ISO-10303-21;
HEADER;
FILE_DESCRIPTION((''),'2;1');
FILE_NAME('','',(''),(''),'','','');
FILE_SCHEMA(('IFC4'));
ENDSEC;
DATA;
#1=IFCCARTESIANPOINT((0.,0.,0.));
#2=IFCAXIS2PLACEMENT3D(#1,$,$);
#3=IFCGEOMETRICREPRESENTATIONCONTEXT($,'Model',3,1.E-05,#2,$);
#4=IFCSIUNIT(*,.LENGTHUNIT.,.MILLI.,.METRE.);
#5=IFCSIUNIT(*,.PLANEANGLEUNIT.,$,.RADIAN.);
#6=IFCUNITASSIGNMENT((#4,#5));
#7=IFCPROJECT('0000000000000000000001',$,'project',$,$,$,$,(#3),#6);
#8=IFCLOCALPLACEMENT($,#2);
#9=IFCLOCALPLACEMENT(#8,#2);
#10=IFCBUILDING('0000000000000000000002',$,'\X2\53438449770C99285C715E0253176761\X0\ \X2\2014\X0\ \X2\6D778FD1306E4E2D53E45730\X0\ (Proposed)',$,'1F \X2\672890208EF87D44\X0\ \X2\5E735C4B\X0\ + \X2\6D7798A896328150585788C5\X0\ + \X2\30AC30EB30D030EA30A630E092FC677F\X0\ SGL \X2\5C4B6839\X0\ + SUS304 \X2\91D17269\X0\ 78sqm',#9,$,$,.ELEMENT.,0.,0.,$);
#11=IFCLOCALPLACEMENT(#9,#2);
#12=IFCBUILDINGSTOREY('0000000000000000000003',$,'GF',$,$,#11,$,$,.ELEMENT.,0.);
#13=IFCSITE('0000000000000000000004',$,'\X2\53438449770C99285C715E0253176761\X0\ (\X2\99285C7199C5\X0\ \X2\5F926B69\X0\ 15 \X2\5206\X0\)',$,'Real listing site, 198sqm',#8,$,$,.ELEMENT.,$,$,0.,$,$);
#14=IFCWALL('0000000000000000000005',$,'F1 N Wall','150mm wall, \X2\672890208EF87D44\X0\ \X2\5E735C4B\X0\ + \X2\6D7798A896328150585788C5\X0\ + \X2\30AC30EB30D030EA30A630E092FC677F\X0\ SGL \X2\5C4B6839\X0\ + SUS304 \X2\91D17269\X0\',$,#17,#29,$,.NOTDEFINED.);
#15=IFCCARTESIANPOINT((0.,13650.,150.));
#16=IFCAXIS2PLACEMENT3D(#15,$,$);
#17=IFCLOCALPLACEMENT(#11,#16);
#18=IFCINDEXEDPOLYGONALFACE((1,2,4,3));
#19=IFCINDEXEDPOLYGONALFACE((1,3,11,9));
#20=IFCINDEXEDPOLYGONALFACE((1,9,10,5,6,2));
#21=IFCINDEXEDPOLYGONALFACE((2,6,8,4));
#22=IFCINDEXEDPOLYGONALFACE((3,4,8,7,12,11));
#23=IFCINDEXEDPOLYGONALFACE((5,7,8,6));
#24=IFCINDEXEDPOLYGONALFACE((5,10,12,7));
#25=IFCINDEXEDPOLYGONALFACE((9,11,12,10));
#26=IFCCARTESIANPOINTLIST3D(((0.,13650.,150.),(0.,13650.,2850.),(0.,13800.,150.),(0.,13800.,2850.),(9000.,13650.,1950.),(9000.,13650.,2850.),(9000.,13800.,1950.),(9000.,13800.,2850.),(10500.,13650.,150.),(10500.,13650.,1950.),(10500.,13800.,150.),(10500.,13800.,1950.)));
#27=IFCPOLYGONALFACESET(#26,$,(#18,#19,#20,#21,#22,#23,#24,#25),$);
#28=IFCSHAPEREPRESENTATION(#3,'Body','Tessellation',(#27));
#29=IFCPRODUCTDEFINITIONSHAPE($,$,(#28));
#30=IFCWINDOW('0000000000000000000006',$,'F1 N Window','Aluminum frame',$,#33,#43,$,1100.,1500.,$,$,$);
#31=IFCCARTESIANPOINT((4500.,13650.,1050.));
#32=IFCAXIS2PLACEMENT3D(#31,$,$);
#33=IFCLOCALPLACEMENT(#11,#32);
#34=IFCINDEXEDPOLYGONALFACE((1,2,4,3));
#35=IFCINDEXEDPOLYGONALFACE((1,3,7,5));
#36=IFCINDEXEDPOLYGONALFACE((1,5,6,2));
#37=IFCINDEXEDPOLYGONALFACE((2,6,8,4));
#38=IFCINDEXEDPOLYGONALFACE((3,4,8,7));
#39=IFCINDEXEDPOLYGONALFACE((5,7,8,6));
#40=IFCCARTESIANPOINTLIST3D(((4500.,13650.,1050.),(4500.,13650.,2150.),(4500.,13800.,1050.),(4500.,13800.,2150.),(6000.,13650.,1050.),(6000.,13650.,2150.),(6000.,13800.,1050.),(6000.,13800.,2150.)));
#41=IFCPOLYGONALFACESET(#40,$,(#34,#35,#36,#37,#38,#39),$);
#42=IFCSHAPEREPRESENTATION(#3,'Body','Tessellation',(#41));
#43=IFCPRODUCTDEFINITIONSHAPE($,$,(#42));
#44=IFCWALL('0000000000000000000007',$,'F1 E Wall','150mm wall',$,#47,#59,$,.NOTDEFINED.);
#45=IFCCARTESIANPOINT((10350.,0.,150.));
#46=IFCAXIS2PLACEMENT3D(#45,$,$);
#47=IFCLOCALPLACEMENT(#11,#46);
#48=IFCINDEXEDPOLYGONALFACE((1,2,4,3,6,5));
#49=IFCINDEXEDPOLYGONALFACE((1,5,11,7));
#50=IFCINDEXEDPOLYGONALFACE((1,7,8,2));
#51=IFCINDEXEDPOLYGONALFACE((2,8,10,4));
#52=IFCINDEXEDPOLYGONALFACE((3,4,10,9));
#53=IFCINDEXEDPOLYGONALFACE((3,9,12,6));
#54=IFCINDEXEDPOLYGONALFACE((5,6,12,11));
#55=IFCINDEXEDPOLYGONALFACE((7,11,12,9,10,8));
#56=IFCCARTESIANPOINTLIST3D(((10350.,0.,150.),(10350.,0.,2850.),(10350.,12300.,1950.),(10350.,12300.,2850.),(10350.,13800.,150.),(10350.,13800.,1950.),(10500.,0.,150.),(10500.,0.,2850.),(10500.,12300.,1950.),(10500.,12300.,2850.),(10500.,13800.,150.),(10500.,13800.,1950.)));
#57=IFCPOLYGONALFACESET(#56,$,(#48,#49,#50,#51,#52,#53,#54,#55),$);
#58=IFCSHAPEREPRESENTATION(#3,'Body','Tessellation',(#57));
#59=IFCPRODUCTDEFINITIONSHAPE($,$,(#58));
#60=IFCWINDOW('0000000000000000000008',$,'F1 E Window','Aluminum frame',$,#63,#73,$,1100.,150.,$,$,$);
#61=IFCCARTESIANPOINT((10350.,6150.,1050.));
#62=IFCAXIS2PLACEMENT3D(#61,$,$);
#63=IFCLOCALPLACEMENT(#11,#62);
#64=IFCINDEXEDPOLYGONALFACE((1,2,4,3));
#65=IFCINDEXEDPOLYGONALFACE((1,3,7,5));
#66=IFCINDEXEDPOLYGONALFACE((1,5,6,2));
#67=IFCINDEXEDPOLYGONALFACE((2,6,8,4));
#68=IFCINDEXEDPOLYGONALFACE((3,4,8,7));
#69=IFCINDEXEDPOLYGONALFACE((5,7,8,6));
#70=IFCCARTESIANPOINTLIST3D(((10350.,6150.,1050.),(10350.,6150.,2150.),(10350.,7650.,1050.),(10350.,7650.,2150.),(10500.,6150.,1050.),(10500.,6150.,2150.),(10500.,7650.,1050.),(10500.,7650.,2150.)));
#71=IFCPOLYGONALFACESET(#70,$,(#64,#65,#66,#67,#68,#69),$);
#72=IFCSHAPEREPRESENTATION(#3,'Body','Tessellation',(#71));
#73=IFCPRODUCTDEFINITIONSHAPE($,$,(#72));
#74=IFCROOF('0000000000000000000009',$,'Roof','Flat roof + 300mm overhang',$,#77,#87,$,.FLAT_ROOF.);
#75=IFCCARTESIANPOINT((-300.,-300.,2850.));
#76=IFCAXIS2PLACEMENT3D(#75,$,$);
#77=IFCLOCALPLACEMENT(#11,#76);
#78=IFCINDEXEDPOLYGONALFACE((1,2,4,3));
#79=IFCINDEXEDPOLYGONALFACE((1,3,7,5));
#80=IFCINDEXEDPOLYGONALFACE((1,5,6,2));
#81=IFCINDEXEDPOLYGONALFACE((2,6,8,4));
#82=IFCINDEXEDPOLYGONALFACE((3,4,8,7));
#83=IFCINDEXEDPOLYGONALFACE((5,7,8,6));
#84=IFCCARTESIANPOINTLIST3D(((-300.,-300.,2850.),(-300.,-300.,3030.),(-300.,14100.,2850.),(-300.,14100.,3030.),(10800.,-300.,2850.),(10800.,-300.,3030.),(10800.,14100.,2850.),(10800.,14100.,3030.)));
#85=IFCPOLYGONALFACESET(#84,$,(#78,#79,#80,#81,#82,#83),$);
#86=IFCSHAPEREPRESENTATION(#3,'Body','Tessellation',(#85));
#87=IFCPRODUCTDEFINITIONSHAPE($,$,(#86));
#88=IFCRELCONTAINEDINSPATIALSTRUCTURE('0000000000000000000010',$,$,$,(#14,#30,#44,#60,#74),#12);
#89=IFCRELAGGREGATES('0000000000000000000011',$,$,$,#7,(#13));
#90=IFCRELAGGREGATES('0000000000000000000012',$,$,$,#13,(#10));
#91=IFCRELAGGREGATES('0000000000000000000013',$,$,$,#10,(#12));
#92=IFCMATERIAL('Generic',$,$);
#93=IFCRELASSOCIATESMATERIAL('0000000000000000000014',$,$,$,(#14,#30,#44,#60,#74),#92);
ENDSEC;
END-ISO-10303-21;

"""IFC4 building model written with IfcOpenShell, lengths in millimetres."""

from ifc_helpers import new_model, si_unit, frame, frame_2d, origin, place, context, project, spatial, rectangle, extrude, material, element, fill, save


model = new_model("IFC4")

# Units and contexts
model_context = context("Model", 3, precision=1e-05, world=origin())
ifc_project = project(units=[si_unit("LENGTHUNIT", "METRE", prefix="MILLI"), si_unit("PLANEANGLEUNIT", "RADIAN")], contexts=[model_context])

# Site, building, storey
site_placement = place(None, origin())
site = spatial("IfcSite", under=ifc_project, at=site_placement, Name="千葉県館山市北条 (館山駅 徒歩 15 分)", ObjectType="Real listing site, 198sqm", CompositionType="ELEMENT", RefElevation=0.0)
building_placement = place(site_placement, origin())
building = spatial("IfcBuilding", under=site, at=building_placement, Name="千葉県館山市北条 — 海近の中古地 (Proposed)", ObjectType="1F 木造軸組 平屋 + 海風防腐塗装 + ガルバリウム鋼板 SGL 屋根 + SUS304 金物 78sqm", CompositionType="ELEMENT", ElevationOfRefHeight=0.0, ElevationOfTerrain=0.0)
storey_placement = place(building_placement, origin())
storey = spatial("IfcBuildingStorey", under=building, at=storey_placement, Name="GF", CompositionType="ELEMENT", Elevation=0.0)

# Wall, opening, window
ifc_material_1 = material(Name="Generic")
wall_1_placement = place(storey_placement, frame((0.0, 13650.0, 150.0)))
wall_1 = element("IfcWall", 1, at=wall_1_placement, inside=storey, material=ifc_material_1, Name="F1 N Wall", Description="150mm wall, 木造軸組 平屋 + 海風防腐塗装 + ガルバリウム鋼板 SGL 屋根 + SUS304 金物", PredefinedType="NOTDEFINED", context=model_context, shape_type="SweptSolid", body=[
    extrude(rectangle(XDim=10500.0, YDim=150.0, at=frame_2d((5250.0, 75.0))), frame((0.0, 13650.0, 150.0)), (0.0, 0.0, 1.0), 2700.0),
])
opening_1_placement = place(storey_placement, frame((4500.0, 13650.0, 1050.0)))
opening_1 = element("IfcOpeningElement", 2, at=opening_1_placement, cuts=wall_1, PredefinedType="NOTDEFINED", context=model_context, shape_type="SweptSolid", body=[
    extrude(rectangle(XDim=1500.0, YDim=150.0, at=frame_2d((750.0, 75.0))), frame((4500.0, 13650.0, 1050.0)), (0.0, 0.0, 1.0), 1100.0),
])
window_1_placement = place(storey_placement, frame((4500.0, 13650.0, 1050.0)))
window_1 = element("IfcWindow", 3, at=window_1_placement, inside=storey, material=ifc_material_1, Name="F1 N Window", Description="Aluminum frame", OverallHeight=1100.0, OverallWidth=1500.0, context=model_context, shape_type="SweptSolid", body=[
    extrude(rectangle(XDim=1500.0, YDim=150.0, at=frame_2d((750.0, 75.0))), frame((4500.0, 13650.0, 1050.0)), (0.0, 0.0, 1.0), 1100.0),
])
fill(opening_1, window_1)

# Wall, opening, window
wall_2_placement = place(storey_placement, frame((10350.0, 0.0, 150.0)))
wall_2 = element("IfcWall", 4, at=wall_2_placement, inside=storey, material=ifc_material_1, Name="F1 E Wall", Description="150mm wall", PredefinedType="NOTDEFINED", context=model_context, shape_type="SweptSolid", body=[
    extrude(rectangle(XDim=150.0, YDim=13800.0, at=frame_2d((75.0, 6900.0))), frame((10350.0, 0.0, 150.0)), (0.0, 0.0, 1.0), 2700.0),
])
opening_2_placement = place(storey_placement, frame((10350.0, 6150.0, 1050.0)))
opening_2 = element("IfcOpeningElement", 5, at=opening_2_placement, cuts=wall_2, PredefinedType="NOTDEFINED", context=model_context, shape_type="SweptSolid", body=[
    extrude(rectangle(XDim=150.0, YDim=1500.0, at=frame_2d((75.0, 750.0))), frame((10350.0, 6150.0, 1050.0)), (0.0, 0.0, 1.0), 1100.0),
])
window_2_placement = place(storey_placement, frame((10350.0, 6150.0, 1050.0)))
window_2 = element("IfcWindow", 6, at=window_2_placement, inside=storey, material=ifc_material_1, Name="F1 E Window", Description="Aluminum frame", OverallHeight=1100.0, OverallWidth=150.0, context=model_context, shape_type="SweptSolid", body=[
    extrude(rectangle(XDim=150.0, YDim=1500.0, at=frame_2d((75.0, 750.0))), frame((10350.0, 6150.0, 1050.0)), (0.0, 0.0, 1.0), 1100.0),
])
fill(opening_2, window_2)

# Roof
roof_placement = place(storey_placement, frame((-300.0, -300.0, 2850.0)))
element("IfcRoof", 7, at=roof_placement, inside=storey, material=ifc_material_1, Name="Roof", Description="Flat roof + 300mm overhang", PredefinedType="FLAT_ROOF", context=model_context, shape_type="SweptSolid", body=[
    extrude(rectangle(XDim=11100.0, YDim=14400.0, at=frame_2d((5550.0, 7200.0))), frame((-300.0, -300.0, 2850.0)), (0.0, 0.0, 1.0), 180.0),
])

save(model, "model.ifc")
